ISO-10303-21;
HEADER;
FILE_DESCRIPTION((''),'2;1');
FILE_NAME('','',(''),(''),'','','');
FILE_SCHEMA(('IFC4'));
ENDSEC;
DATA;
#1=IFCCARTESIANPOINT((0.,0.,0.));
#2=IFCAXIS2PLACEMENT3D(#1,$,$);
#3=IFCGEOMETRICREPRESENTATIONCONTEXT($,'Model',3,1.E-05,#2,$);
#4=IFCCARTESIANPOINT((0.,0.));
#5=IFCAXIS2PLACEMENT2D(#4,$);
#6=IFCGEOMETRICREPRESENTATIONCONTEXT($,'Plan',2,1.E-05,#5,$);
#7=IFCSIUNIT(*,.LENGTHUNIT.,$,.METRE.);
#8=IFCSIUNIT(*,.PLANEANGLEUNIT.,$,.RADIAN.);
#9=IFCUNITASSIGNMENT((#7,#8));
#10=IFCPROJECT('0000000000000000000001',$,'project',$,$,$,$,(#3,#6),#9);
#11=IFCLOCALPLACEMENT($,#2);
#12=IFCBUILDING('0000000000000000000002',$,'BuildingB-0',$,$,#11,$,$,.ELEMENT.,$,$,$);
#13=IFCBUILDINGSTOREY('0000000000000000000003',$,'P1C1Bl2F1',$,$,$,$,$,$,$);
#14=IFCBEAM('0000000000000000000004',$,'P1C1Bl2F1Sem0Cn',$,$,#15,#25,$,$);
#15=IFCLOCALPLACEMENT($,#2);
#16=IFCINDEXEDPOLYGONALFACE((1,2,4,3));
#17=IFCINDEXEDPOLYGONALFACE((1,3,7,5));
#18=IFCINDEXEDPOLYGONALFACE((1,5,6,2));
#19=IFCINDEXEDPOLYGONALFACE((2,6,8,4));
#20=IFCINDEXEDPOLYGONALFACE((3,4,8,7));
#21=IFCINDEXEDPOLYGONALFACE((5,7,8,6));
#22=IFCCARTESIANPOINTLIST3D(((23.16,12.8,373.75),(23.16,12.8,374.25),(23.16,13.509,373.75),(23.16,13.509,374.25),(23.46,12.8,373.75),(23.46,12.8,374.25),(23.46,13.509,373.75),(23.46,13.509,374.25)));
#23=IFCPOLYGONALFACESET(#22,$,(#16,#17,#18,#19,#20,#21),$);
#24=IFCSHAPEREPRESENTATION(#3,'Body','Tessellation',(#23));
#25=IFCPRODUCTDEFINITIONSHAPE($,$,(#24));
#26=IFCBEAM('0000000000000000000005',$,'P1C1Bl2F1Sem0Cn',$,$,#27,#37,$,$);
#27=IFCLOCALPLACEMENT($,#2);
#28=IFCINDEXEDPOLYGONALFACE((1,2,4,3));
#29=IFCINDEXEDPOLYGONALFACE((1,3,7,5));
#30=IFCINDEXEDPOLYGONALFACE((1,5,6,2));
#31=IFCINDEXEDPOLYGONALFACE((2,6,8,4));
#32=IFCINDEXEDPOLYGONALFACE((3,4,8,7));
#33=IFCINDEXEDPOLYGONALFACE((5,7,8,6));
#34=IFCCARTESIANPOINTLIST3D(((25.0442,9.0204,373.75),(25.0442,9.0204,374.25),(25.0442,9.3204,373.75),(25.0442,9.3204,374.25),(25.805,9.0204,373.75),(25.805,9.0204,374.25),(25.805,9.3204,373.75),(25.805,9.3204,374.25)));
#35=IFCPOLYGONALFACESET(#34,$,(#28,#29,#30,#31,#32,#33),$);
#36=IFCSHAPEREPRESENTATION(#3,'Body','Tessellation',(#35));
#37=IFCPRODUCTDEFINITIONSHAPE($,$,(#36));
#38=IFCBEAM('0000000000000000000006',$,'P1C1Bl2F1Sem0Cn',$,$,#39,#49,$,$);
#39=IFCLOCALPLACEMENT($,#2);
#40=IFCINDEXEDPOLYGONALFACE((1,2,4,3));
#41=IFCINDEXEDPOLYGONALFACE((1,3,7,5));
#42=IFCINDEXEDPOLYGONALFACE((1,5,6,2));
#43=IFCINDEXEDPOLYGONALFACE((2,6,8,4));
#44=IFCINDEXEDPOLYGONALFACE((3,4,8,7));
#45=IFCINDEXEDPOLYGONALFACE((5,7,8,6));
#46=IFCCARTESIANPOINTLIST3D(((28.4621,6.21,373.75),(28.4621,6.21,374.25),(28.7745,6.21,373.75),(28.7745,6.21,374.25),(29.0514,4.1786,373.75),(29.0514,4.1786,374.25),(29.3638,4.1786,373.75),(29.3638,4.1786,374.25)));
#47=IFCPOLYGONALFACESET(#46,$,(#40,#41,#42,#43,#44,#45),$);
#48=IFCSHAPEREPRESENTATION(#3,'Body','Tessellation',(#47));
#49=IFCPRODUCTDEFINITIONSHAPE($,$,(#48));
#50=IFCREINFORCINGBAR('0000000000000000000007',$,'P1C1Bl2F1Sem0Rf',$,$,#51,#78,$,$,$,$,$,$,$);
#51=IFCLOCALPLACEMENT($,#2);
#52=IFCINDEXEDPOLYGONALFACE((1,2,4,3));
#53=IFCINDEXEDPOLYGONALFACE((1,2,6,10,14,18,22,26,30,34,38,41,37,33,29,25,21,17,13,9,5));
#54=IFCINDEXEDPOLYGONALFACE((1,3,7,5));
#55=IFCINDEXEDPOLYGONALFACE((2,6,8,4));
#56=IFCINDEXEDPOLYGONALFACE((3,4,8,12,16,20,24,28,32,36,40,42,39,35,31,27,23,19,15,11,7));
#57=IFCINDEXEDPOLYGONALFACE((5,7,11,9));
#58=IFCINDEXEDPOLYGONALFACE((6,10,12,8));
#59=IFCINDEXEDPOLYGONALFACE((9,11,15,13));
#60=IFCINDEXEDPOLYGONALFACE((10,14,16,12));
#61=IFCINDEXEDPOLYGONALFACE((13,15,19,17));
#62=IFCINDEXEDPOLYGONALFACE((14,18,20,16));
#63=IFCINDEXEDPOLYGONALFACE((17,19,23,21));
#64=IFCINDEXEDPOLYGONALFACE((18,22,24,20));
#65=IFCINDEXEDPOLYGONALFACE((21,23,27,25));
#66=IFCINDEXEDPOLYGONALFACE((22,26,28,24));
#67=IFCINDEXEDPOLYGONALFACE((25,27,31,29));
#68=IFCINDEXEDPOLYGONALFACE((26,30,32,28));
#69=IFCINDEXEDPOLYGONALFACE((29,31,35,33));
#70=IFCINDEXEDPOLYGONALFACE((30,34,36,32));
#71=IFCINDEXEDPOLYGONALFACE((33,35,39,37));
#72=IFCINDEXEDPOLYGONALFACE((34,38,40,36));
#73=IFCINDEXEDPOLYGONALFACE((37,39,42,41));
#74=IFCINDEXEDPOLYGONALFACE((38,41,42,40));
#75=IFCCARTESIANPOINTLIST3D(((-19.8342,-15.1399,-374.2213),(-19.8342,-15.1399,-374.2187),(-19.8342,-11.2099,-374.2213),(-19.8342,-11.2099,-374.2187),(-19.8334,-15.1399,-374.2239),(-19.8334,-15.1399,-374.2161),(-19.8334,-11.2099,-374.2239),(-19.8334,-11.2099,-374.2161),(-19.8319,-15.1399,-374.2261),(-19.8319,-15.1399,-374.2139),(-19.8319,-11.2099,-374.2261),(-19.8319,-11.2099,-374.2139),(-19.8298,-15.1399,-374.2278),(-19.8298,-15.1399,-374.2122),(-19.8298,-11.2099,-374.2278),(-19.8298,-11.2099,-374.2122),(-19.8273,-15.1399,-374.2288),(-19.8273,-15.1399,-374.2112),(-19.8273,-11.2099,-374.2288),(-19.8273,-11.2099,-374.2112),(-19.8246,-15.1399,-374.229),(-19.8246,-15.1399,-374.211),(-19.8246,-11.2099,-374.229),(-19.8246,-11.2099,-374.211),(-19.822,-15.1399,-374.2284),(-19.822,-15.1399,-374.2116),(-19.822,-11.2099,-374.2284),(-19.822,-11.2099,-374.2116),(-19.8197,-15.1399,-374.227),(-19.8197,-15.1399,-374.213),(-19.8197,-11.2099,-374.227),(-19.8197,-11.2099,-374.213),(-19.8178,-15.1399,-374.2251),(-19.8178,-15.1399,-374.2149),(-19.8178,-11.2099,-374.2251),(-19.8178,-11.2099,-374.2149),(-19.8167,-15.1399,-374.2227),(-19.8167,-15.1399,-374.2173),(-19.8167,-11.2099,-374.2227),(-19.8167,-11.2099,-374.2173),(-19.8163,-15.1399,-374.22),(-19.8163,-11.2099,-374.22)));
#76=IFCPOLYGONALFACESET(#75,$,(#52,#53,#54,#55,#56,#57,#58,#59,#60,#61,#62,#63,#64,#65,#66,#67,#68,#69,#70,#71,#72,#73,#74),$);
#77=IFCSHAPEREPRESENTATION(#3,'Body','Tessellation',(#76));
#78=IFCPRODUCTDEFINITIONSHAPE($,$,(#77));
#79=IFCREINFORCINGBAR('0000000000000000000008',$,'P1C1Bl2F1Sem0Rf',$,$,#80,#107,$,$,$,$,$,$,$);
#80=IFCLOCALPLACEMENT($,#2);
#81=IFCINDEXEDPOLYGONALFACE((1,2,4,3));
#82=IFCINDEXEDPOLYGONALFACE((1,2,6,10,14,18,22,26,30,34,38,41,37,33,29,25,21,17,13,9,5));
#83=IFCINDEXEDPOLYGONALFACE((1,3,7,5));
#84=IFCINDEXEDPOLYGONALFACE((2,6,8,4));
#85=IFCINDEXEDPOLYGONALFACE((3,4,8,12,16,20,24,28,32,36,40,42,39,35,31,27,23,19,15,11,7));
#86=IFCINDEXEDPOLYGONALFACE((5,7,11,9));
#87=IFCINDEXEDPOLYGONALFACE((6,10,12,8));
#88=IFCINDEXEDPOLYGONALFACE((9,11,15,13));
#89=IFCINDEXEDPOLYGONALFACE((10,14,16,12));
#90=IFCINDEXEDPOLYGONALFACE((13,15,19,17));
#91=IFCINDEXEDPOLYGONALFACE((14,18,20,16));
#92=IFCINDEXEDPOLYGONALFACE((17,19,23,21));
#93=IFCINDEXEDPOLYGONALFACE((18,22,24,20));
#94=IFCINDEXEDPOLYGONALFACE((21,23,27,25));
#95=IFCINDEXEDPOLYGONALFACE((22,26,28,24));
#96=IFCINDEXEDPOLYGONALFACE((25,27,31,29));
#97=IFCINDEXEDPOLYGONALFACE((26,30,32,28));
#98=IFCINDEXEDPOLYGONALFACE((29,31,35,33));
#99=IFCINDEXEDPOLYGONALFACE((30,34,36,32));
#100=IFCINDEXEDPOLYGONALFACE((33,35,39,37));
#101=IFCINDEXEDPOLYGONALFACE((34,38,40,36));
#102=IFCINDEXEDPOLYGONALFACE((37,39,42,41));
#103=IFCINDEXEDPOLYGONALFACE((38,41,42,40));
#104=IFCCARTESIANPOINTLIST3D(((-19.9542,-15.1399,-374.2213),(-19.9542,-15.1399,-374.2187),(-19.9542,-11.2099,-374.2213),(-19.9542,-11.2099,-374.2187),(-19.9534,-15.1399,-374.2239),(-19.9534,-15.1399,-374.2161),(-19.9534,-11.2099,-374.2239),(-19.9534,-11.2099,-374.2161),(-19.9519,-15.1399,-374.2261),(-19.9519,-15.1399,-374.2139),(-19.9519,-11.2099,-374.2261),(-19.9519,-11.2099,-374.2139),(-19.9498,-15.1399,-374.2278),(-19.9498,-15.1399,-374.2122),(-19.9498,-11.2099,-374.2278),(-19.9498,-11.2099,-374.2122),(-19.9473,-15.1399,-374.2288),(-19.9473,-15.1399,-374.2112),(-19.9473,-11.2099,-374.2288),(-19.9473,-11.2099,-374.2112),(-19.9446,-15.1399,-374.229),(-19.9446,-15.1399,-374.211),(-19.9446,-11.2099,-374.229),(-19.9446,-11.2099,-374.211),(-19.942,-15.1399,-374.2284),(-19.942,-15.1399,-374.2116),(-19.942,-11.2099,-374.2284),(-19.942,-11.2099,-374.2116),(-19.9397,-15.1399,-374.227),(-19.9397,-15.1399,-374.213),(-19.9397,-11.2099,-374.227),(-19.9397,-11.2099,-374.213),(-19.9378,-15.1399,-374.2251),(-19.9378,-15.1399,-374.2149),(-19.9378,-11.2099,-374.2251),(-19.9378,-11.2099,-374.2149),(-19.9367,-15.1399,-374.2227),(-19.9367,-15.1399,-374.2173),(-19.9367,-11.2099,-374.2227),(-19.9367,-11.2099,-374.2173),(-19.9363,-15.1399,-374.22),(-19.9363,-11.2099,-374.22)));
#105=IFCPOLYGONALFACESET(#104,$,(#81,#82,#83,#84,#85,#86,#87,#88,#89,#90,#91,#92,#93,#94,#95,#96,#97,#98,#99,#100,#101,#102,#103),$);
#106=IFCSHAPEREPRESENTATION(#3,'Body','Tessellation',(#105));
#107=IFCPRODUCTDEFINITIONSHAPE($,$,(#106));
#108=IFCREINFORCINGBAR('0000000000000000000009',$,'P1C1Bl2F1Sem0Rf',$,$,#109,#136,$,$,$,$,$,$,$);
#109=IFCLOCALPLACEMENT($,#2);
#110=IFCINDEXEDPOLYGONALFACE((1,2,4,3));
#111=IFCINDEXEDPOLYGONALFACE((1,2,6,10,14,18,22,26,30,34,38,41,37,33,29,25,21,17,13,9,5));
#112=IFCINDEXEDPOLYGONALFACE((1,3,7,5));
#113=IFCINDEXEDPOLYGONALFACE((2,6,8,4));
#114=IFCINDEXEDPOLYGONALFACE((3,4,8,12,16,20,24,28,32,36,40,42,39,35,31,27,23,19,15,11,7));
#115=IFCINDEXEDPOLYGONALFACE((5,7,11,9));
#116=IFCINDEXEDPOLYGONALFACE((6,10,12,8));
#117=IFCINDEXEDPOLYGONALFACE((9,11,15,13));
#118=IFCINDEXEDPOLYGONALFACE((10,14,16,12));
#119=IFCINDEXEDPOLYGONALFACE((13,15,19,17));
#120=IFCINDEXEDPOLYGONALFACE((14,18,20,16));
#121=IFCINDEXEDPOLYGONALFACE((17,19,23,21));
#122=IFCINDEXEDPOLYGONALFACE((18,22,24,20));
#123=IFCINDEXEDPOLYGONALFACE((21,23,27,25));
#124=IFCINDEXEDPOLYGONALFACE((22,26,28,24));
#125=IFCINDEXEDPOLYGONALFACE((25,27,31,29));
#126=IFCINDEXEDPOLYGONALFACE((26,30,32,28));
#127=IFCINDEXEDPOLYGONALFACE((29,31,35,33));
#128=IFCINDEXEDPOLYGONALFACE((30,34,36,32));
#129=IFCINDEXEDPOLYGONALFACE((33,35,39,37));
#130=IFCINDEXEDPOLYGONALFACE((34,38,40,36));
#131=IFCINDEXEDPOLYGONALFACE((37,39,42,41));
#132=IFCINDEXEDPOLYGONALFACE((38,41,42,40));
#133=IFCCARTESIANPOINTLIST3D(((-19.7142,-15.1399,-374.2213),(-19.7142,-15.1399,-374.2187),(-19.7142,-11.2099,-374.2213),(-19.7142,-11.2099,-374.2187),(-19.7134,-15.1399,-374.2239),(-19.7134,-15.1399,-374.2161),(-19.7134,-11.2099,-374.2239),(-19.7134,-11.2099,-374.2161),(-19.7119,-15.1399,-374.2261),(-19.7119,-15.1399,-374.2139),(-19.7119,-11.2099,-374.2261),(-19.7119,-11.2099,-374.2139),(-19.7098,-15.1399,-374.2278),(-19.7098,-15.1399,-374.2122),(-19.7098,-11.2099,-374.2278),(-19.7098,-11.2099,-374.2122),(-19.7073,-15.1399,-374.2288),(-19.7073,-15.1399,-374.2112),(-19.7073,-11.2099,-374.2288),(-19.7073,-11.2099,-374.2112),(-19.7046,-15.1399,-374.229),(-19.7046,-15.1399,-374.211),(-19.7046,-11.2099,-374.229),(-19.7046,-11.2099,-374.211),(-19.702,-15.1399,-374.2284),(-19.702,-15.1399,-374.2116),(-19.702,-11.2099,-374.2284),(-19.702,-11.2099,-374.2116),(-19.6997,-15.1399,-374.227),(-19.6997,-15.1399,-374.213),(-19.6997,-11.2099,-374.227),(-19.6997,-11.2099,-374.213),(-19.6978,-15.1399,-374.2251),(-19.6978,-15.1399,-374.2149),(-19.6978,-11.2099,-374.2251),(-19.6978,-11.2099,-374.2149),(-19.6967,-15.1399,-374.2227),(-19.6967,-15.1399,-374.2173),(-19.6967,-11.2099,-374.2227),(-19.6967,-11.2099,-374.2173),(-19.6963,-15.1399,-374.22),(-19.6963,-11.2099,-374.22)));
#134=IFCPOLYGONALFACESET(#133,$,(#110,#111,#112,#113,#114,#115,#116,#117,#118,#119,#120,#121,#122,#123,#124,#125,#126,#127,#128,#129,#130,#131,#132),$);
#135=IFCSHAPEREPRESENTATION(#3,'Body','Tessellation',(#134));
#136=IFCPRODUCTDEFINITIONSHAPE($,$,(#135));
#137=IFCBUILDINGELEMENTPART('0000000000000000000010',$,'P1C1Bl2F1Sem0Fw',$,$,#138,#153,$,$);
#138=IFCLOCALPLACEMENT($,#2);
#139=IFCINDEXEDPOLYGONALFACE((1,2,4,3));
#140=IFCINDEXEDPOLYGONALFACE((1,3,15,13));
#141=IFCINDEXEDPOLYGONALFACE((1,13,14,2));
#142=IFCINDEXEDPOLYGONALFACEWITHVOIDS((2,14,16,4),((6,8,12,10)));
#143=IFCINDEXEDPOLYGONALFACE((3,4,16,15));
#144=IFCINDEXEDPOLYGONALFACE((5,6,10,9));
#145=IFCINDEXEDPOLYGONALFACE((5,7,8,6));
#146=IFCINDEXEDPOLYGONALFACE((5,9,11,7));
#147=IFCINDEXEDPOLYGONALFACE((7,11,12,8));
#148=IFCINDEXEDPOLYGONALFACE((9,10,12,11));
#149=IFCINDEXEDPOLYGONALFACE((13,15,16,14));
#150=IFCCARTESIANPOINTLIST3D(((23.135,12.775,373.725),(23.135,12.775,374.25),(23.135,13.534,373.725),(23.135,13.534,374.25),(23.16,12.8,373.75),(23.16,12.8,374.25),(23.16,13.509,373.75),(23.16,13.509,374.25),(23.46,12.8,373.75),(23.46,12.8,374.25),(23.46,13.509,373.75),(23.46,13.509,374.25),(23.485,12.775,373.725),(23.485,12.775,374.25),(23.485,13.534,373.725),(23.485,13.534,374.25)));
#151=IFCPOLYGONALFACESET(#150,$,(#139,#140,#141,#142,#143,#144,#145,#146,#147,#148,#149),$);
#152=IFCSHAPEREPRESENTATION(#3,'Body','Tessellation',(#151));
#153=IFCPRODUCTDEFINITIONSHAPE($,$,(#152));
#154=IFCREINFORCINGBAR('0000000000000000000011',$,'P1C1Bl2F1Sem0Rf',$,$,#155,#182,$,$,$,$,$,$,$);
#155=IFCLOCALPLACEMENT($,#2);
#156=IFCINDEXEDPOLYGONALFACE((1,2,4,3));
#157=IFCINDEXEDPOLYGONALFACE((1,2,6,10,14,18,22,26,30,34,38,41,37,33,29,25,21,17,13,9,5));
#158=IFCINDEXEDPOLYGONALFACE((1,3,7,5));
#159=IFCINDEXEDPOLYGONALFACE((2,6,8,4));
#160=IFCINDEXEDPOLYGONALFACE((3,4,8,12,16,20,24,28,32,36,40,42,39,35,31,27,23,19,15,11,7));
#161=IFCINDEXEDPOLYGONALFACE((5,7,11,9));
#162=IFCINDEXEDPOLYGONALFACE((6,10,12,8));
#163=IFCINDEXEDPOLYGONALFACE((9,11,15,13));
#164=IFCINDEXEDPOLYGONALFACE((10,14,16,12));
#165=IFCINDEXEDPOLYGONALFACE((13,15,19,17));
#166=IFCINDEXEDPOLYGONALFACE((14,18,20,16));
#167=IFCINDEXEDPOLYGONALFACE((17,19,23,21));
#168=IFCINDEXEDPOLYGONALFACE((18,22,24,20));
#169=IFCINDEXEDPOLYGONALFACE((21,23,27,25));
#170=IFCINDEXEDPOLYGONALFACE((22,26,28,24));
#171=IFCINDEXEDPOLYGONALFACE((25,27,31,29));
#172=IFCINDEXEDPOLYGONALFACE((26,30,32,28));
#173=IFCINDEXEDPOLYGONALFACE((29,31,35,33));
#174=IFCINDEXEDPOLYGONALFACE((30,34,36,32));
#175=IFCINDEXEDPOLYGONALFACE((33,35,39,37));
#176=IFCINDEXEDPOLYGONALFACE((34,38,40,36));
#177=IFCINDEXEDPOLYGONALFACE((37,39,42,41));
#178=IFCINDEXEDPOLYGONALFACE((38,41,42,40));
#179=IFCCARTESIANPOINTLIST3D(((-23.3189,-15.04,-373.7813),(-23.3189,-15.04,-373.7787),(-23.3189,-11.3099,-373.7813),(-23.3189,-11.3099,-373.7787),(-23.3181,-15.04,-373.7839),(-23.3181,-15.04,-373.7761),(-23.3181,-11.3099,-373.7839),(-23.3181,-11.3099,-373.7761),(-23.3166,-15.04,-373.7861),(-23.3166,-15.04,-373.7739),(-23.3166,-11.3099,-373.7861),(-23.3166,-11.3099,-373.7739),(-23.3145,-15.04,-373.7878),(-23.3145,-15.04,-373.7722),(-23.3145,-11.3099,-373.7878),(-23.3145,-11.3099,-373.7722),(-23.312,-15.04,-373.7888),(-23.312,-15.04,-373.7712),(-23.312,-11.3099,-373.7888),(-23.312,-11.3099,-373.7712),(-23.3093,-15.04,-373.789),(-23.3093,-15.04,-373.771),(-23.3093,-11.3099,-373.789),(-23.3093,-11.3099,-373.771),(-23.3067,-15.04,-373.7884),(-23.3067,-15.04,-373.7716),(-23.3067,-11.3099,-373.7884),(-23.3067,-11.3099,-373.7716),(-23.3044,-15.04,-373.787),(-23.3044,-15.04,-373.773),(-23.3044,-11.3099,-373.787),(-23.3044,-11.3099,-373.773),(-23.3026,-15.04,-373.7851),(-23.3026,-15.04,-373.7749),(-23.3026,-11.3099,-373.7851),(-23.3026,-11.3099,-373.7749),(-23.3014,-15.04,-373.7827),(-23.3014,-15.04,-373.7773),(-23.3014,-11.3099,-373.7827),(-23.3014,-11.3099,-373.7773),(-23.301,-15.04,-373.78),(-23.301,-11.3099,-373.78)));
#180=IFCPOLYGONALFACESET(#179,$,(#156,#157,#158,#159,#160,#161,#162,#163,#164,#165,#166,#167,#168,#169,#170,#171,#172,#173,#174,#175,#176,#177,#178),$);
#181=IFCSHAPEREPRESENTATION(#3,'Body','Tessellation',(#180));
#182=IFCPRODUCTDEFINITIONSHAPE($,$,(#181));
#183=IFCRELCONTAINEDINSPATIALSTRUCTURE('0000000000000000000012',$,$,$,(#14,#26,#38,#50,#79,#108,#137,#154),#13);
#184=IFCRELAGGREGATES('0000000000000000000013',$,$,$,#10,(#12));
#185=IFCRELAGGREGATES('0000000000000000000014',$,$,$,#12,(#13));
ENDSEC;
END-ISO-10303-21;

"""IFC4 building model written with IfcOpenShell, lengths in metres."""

from ifc_helpers import new_model, entity, si_unit, origin, origin_2d, place, context, project, spatial, polyline, outline, extrude, element, save


model = new_model("IFC4")

# Units and contexts
model_context = context("Model", 3, precision=1e-05, world=origin())
plan_context = context("Plan", 2, precision=1e-05, world=origin_2d())
ifc_project = project(units=[si_unit("LENGTHUNIT", "METRE"), si_unit("PLANEANGLEUNIT", "RADIAN")], contexts=[model_context, plan_context])

# Building, storey
building_placement = place(None, origin())
building = spatial("IfcBuilding", under=ifc_project, at=building_placement, Name="BuildingB-0", CompositionType="ELEMENT")
storey = spatial("IfcBuildingStorey", under=building, Name="P1C1Bl2F1")

# Beams
element("IfcBeam", 1, inside=storey, Name="P1C1Bl2F1Sem0Cn", context=model_context, shape_type="SweptSolid", body=[
    extrude(outline(polyline([(23.16, 12.8, 373.75), (23.46, 12.8, 373.75), (23.46, 13.509, 373.75), (23.16, 13.509, 373.75), (23.16, 12.8, 373.75)])), None, (0.0, 0.0, 1.0), 0.5),
])
element("IfcBeam", 2, inside=storey, Name="P1C1Bl2F1Sem0Cn", context=model_context, shape_type="SweptSolid", body=[
    extrude(outline(polyline([(25.0442, 9.0204, 373.75), (25.805, 9.0204, 373.75), (25.805, 9.3204, 373.75), (25.0442, 9.3204, 373.75), (25.0442, 9.0204, 373.75)])), None, (0.0, 0.0, 1.0), 0.5),
])
element("IfcBeam", 3, inside=storey, Name="P1C1Bl2F1Sem0Cn", context=model_context, shape_type="SweptSolid", body=[
    extrude(outline(polyline([(29.0514, 4.1786, 373.75), (29.3638, 4.1786, 373.75), (28.7745, 6.21, 373.75), (28.4621, 6.21, 373.75), (29.0514, 4.1786, 373.75)])), None, (0.0, 0.0, 1.0), 0.5),
])

# Reinforcing bars
element("IfcReinforcingBar", 4, inside=storey, Name="P1C1Bl2F1Sem0Rf", context=model_context, shape_type="SweptSolid", body=[
    entity("IfcSurfaceCurveSweptAreaSolid", entity("IfcCircleProfileDef", "AREA", None, None, 0.009), None, entity("IfcPolyline", [entity("IfcCartesianPoint", [19.8253, 11.2099, 374.22]), entity("IfcCartesianPoint", [19.8253, 15.1399, 374.22])]), None, None, entity("IfcPlane", entity("IfcAxis2Placement3D", entity("IfcCartesianPoint", [19.8253, 11.2099, 374.22]), entity("IfcDirection", [0.0, 0.0, 1.0]), entity("IfcDirection", [1.0, 0.0, 0.0])))),
])
element("IfcReinforcingBar", 5, inside=storey, Name="P1C1Bl2F1Sem0Rf", context=model_context, shape_type="SweptSolid", body=[
    entity("IfcSurfaceCurveSweptAreaSolid", entity("IfcCircleProfileDef", "AREA", None, None, 0.009), None, entity("IfcPolyline", [entity("IfcCartesianPoint", [19.9453, 11.2099, 374.22]), entity("IfcCartesianPoint", [19.9453, 15.1399, 374.22])]), None, None, entity("IfcPlane", entity("IfcAxis2Placement3D", entity("IfcCartesianPoint", [19.9453, 11.2099, 374.22]), entity("IfcDirection", [0.0, 0.0, 1.0]), entity("IfcDirection", [1.0, 0.0, 0.0])))),
])
element("IfcReinforcingBar", 6, inside=storey, Name="P1C1Bl2F1Sem0Rf", context=model_context, shape_type="SweptSolid", body=[
    entity("IfcSurfaceCurveSweptAreaSolid", entity("IfcCircleProfileDef", "AREA", None, None, 0.009), None, entity("IfcPolyline", [entity("IfcCartesianPoint", [19.7053, 11.2099, 374.22]), entity("IfcCartesianPoint", [19.7053, 15.1399, 374.22])]), None, None, entity("IfcPlane", entity("IfcAxis2Placement3D", entity("IfcCartesianPoint", [19.7053, 11.2099, 374.22]), entity("IfcDirection", [0.0, 0.0, 1.0]), entity("IfcDirection", [1.0, 0.0, 0.0])))),
])

# Building element part, opening
building_element_part_1 = element("IfcBuildingElementPart", 7, inside=storey, Name="P1C1Bl2F1Sem0Fw", context=model_context, shape_type="SweptSolid", body=[
    extrude(outline(polyline([(23.135, 12.775, 373.725), (23.485, 12.775, 373.725), (23.485, 13.534, 373.725), (23.135, 13.534, 373.725), (23.135, 12.775, 373.725)])), None, (0.0, 0.0, 1.0), 0.525),
])
element("IfcOpeningElement", 8, inside=storey, cuts=building_element_part_1, context=model_context, shape_type="SweptSolid", body=[
    extrude(outline(polyline([(23.16, 12.8, 373.75), (23.46, 12.8, 373.75), (23.46, 13.509, 373.75), (23.16, 13.509, 373.75), (23.16, 12.8, 373.75)])), None, (0.0, 0.0, 1.0), 0.5),
])

# Reinforcing bar
element("IfcReinforcingBar", 9, inside=storey, Name="P1C1Bl2F1Sem0Rf", context=model_context, shape_type="SweptSolid", body=[
    entity("IfcSurfaceCurveSweptAreaSolid", entity("IfcCircleProfileDef", "AREA", None, None, 0.009), None, entity("IfcPolyline", [entity("IfcCartesianPoint", [23.31, 11.3099, 373.78]), entity("IfcCartesianPoint", [23.31, 15.04, 373.78])]), None, None, entity("IfcPlane", entity("IfcAxis2Placement3D", entity("IfcCartesianPoint", [23.31, 11.3099, 373.78]), entity("IfcDirection", [0.0, 0.0, 1.0]), entity("IfcDirection", [1.0, 0.0, 0.0])))),
])

save(model, "model.ifc")
